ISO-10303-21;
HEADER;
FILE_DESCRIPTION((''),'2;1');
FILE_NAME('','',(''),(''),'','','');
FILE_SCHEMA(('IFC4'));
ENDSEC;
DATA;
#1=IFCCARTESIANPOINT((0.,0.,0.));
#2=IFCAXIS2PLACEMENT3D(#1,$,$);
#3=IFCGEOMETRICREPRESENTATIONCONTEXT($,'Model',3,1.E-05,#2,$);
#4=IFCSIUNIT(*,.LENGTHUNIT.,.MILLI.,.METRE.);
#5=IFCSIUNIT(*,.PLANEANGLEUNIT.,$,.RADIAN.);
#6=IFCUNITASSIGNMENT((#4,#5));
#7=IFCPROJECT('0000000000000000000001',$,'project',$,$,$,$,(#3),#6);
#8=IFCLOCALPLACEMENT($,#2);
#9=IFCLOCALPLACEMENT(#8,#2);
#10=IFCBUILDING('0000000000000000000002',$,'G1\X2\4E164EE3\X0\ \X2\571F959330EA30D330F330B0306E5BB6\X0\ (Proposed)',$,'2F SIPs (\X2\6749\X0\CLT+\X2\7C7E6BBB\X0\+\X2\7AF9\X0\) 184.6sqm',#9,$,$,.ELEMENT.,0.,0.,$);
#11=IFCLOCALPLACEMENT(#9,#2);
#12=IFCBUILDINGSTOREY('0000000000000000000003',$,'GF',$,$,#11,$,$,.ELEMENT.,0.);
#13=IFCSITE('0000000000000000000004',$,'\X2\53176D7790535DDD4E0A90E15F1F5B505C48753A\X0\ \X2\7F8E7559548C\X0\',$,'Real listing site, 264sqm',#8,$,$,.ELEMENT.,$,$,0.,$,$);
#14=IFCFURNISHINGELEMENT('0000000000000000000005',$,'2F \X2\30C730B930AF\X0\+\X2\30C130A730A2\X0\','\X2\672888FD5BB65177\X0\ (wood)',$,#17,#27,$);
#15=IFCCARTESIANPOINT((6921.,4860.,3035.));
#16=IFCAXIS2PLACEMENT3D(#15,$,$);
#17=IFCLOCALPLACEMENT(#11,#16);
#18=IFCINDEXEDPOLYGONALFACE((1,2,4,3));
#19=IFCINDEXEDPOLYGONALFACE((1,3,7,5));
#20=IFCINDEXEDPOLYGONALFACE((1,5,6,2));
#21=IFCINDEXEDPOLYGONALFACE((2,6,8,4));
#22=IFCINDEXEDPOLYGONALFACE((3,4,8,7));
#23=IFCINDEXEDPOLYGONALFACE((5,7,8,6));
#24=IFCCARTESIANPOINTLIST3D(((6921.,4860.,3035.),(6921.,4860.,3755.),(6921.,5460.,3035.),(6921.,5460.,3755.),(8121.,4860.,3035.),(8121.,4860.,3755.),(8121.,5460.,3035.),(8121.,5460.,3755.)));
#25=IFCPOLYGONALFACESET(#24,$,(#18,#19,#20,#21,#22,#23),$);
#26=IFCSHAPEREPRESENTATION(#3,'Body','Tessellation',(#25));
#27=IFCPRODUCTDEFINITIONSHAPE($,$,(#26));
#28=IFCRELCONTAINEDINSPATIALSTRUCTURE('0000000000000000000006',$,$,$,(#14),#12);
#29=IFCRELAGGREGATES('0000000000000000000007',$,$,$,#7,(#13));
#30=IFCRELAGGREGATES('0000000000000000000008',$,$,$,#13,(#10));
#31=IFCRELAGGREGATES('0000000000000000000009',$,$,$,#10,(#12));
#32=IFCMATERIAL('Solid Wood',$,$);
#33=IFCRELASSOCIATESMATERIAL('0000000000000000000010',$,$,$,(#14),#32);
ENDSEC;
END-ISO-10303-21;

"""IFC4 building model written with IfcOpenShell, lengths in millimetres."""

from ifc_helpers import new_model, si_unit, frame, frame_2d, origin, place, context, project, spatial, rectangle, extrude, material, element, save


model = new_model("IFC4")

# Units and contexts
model_context = context("Model", 3, precision=1e-05, world=origin())
ifc_project = project(units=[si_unit("LENGTHUNIT", "METRE", prefix="MILLI"), si_unit("PLANEANGLEUNIT", "RADIAN")], contexts=[model_context])

# Site, building, storey
site_placement = place(None, origin())
site = spatial("IfcSite", under=ifc_project, at=site_placement, Name="北海道川上郡弟子屈町 美留和", ObjectType="Real listing site, 264sqm", CompositionType="ELEMENT", RefElevation=0.0)
building_placement = place(site_placement, origin())
building = spatial("IfcBuilding", under=site, at=building_placement, Name="G1世代 土間リビングの家 (Proposed)", ObjectType="2F SIPs (杉CLT+籾殻+竹) 184.6sqm", CompositionType="ELEMENT", ElevationOfRefHeight=0.0, ElevationOfTerrain=0.0)
storey_placement = place(building_placement, origin())
storey = spatial("IfcBuildingStorey", under=building, at=storey_placement, Name="GF", CompositionType="ELEMENT", Elevation=0.0)

# Shared definitions
ifc_material_1 = material(Name="Solid Wood")

# Furnishing element
furnishing_1_placement = place(storey_placement, frame((6921.0, 4860.0, 3035.0)))
element("IfcFurnishingElement", 1, at=furnishing_1_placement, inside=storey, material=ifc_material_1, Name="2F デスク+チェア", Description="木製家具 (wood)", context=model_context, shape_type="SweptSolid", body=[
    extrude(rectangle(XDim=1200.0, YDim=600.0, at=frame_2d((600.0, 300.0))), frame((6921.0, 4860.0, 3035.0)), (0.0, 0.0, 1.0), 720.0),
])

save(model, "model.ifc")
